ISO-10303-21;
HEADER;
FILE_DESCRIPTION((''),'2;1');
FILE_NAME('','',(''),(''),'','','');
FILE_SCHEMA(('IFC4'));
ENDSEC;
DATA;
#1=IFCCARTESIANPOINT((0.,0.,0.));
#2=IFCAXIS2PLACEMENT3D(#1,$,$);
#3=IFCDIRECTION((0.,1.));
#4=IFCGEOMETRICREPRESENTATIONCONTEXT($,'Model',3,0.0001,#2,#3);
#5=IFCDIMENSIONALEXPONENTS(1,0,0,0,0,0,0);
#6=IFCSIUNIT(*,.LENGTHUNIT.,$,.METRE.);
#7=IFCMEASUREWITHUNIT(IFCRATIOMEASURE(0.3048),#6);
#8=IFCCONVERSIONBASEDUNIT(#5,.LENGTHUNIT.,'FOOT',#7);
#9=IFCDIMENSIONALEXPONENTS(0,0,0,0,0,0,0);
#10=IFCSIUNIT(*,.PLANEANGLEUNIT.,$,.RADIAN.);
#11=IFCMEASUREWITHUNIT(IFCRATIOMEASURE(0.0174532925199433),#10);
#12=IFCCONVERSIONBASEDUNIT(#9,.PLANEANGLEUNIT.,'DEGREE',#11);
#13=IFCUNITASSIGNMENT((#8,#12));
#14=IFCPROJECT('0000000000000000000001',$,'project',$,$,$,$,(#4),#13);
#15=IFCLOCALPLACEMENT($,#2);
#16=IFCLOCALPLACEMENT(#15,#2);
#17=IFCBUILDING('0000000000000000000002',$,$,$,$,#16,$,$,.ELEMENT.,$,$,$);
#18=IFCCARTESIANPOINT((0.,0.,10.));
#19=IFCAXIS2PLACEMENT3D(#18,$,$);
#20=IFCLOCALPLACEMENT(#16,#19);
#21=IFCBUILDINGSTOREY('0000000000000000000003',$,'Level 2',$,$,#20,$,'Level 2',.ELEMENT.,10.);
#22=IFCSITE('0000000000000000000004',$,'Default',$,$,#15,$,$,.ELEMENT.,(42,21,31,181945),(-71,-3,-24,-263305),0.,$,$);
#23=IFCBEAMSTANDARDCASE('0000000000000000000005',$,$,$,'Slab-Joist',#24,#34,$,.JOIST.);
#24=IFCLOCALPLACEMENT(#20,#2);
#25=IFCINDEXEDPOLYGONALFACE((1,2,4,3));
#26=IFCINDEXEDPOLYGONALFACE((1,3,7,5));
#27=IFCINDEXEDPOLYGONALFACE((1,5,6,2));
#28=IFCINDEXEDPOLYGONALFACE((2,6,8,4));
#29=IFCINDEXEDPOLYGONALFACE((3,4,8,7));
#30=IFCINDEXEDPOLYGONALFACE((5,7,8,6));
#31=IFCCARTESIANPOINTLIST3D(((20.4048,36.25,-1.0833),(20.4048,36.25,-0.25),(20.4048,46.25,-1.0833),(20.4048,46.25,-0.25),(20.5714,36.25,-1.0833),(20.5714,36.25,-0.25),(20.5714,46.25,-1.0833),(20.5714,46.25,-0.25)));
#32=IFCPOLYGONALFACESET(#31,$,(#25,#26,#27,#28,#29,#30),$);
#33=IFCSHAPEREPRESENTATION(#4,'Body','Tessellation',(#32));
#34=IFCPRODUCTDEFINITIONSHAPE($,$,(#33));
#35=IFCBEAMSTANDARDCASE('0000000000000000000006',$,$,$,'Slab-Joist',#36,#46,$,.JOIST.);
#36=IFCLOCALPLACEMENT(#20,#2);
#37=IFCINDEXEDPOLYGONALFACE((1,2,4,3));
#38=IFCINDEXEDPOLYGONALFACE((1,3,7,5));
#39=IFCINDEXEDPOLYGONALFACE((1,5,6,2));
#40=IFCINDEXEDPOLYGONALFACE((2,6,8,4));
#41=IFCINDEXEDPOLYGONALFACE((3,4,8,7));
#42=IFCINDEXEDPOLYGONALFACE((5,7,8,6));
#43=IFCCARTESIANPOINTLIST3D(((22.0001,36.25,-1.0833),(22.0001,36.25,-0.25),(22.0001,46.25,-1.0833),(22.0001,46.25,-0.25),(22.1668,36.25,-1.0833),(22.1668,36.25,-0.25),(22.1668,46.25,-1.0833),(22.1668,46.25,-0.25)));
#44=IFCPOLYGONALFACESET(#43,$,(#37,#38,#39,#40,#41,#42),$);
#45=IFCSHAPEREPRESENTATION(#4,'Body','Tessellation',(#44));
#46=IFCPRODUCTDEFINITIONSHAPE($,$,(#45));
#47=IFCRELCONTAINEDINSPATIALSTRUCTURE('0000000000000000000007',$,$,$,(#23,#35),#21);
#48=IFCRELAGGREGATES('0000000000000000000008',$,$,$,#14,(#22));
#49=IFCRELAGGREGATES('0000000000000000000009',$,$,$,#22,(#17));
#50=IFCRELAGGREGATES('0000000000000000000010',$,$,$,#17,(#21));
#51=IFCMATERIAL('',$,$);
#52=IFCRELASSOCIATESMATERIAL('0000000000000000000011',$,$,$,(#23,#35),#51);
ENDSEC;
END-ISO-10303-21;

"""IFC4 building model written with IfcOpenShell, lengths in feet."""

from ifc_helpers import new_model, entity, si_unit, converted_unit, direction, frame, origin, origin_with_axes, place, context, project, spatial, rectangle, extrude, material, element, save


model = new_model("IFC4")

# Units and contexts
model_context = context("Model", 3, precision=0.0001, world=origin(), true_north=direction((0.0, 1.0)))
ifc_project = project(units=[converted_unit("LENGTHUNIT", "FOOT", entity("IfcRatioMeasure", 0.3048), si_unit("LENGTHUNIT", "METRE"), dimensions=[1, 0, 0, 0, 0, 0, 0]), converted_unit("PLANEANGLEUNIT", "DEGREE", entity("IfcRatioMeasure", 0.0174532925199433), si_unit("PLANEANGLEUNIT", "RADIAN"), dimensions=[0, 0, 0, 0, 0, 0, 0])], contexts=[model_context])

# Site, building, storey
site_placement = place(None, origin())
site = spatial("IfcSite", under=ifc_project, at=site_placement, Name="Default", CompositionType="ELEMENT", RefLatitude=(42, 21, 31, 181945), RefLongitude=(-71, -3, -24, -263305), RefElevation=0.0)
building_placement = place(site_placement, origin())
building = spatial("IfcBuilding", under=site, at=building_placement, CompositionType="ELEMENT")
storey_placement = place(building_placement, frame((0.0, 0.0, 10.0)))
storey = spatial("IfcBuildingStorey", under=building, at=storey_placement, Name="Level 2", LongName="Level 2", CompositionType="ELEMENT", Elevation=10.0)

# Beams
ifc_material = material(Name="")
placement_1 = place(storey_placement, frame((-0.25, 36.25, 0.0), z_axis=(0.0, 0.0, 1.0), x_axis=(1.0, 0.0, 0.0)))
beam_1_placement = place(placement_1, frame((20.7381, 0.0, -0.6667), z_axis=(0.0, 1.0, 0.0), x_axis=(-1.0, 0.0, 0.0)))
element("IfcBeamStandardCase", 1, at=beam_1_placement, inside=storey, material=ifc_material, ObjectType="Slab-Joist", PredefinedType="JOIST", context=model_context, shape_type="SweptSolid", body=[
    extrude(rectangle(XDim=0.1667, YDim=0.8333), origin_with_axes(), (0.0, 0.0, 1.0), 10.0),
])
placement_2 = place(storey_placement, frame((-0.25, 36.25, 0.0), z_axis=(0.0, 0.0, 1.0), x_axis=(1.0, 0.0, 0.0)))
beam_2_placement = place(placement_2, frame((22.3334, 0.0, -0.6667), z_axis=(0.0, 1.0, 0.0), x_axis=(-1.0, 0.0, 0.0)))
element("IfcBeamStandardCase", 2, at=beam_2_placement, inside=storey, material=ifc_material, ObjectType="Slab-Joist", PredefinedType="JOIST", context=model_context, shape_type="SweptSolid", body=[
    extrude(rectangle(XDim=0.1667, YDim=0.8333), origin_with_axes(), (0.0, 0.0, 1.0), 10.0),
])

save(model, "model.ifc")
